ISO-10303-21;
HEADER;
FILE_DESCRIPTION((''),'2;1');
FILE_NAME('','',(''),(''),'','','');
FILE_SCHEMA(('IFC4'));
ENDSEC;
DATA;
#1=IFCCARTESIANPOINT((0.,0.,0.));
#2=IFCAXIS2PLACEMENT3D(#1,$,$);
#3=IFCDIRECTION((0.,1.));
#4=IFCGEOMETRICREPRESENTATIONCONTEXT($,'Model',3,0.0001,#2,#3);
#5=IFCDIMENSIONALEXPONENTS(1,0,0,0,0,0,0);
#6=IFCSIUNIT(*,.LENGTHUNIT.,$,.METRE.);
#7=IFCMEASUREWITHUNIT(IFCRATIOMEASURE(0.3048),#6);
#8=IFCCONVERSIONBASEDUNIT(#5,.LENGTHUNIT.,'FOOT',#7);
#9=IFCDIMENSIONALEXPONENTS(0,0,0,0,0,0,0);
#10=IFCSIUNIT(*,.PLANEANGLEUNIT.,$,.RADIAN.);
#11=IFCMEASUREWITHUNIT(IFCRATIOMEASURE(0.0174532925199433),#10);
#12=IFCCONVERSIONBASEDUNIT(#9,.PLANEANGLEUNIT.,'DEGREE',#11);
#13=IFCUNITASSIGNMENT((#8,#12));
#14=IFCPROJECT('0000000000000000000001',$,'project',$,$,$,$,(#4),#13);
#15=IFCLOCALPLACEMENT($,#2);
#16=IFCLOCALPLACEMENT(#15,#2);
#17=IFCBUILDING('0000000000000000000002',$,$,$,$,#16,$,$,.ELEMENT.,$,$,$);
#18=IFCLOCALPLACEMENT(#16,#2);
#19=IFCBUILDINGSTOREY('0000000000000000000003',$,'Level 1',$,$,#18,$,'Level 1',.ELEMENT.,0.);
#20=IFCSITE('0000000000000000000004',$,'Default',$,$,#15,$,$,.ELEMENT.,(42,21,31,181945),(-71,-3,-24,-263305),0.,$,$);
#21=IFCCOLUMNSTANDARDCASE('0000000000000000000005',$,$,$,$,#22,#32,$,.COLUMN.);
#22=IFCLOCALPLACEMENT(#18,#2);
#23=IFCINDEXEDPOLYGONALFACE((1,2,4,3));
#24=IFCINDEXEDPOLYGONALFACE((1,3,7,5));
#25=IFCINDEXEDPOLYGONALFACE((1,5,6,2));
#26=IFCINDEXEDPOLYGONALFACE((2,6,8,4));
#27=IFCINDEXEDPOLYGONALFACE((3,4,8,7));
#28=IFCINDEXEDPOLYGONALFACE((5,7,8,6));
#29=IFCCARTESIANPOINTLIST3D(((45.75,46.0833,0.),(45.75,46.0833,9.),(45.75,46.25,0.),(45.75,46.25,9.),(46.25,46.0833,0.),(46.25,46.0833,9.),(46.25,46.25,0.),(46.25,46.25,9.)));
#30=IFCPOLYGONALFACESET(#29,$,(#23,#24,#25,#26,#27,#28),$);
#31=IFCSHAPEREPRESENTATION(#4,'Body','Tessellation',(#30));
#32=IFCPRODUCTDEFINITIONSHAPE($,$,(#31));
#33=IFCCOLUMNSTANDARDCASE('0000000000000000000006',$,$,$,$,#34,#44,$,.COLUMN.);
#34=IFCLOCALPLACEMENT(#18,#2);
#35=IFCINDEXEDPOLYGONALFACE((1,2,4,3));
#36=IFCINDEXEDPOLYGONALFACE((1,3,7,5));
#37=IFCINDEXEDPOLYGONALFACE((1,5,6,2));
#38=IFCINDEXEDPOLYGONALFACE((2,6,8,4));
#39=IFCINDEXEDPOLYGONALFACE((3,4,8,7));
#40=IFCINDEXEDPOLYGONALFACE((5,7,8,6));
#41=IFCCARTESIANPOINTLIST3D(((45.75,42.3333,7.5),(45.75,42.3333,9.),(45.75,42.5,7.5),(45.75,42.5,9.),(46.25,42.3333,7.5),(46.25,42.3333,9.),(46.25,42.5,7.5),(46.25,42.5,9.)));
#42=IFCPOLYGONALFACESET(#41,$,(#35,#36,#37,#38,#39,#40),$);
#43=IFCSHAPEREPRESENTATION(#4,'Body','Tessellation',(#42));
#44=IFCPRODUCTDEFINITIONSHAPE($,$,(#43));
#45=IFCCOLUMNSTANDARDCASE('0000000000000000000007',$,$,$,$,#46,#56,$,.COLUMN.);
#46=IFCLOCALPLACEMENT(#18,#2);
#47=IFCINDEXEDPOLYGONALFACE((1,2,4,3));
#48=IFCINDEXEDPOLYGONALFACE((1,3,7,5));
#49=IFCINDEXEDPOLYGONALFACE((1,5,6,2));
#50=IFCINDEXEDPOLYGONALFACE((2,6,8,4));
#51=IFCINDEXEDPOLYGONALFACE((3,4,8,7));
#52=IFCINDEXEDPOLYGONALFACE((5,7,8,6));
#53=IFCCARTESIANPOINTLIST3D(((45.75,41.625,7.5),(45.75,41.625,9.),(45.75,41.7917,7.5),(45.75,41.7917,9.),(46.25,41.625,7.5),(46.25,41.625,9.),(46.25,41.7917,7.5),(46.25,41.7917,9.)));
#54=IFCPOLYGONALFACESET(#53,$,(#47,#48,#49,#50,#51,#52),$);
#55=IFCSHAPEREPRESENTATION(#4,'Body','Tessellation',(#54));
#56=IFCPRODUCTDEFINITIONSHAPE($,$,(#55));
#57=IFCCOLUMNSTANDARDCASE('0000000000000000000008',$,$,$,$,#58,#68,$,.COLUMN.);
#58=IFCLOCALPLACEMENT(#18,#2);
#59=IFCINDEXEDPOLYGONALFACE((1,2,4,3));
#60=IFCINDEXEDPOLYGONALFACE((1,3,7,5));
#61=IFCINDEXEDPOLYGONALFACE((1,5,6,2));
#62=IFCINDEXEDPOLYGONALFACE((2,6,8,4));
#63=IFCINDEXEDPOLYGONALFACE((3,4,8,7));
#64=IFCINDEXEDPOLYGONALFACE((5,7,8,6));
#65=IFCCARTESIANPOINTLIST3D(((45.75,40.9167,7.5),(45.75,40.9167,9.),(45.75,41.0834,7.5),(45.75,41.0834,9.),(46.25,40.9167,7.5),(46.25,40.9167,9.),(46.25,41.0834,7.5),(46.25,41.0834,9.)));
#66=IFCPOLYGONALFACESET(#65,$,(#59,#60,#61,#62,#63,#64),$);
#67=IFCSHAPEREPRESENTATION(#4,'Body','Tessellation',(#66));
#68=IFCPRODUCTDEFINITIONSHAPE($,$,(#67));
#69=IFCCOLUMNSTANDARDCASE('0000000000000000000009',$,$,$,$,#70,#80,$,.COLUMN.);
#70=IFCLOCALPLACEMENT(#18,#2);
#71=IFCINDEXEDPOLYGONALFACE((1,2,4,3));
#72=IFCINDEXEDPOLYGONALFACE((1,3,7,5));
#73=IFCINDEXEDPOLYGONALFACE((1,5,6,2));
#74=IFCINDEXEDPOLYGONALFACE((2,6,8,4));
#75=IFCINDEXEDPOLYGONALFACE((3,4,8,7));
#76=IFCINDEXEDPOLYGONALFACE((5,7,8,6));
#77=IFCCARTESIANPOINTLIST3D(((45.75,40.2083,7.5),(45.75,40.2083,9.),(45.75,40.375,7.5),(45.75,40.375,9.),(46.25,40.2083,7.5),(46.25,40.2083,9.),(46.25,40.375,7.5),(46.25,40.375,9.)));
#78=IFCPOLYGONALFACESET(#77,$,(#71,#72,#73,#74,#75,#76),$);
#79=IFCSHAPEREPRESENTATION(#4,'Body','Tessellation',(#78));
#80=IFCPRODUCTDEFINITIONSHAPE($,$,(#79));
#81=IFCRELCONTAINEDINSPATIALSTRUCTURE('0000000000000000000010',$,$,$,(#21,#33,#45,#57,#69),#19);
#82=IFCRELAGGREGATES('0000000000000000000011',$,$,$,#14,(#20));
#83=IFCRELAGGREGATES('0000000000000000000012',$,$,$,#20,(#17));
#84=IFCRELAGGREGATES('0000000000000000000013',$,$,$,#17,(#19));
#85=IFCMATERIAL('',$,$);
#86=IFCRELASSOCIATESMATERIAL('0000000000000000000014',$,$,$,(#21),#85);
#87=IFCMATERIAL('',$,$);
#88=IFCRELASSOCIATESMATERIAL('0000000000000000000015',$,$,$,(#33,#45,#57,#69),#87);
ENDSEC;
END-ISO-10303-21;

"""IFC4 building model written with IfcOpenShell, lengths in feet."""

from ifc_helpers import new_model, entity, si_unit, converted_unit, direction, frame, origin, place, context, project, spatial, rectangle, extrude, material, element, save


model = new_model("IFC4")

# Units and contexts
model_context = context("Model", 3, precision=0.0001, world=origin(), true_north=direction((0.0, 1.0)))
ifc_project = project(units=[converted_unit("LENGTHUNIT", "FOOT", entity("IfcRatioMeasure", 0.3048), si_unit("LENGTHUNIT", "METRE"), dimensions=[1, 0, 0, 0, 0, 0, 0]), converted_unit("PLANEANGLEUNIT", "DEGREE", entity("IfcRatioMeasure", 0.0174532925199433), si_unit("PLANEANGLEUNIT", "RADIAN"), dimensions=[0, 0, 0, 0, 0, 0, 0])], contexts=[model_context])

# Site, building, storey
site_placement = place(None, origin())
site = spatial("IfcSite", under=ifc_project, at=site_placement, Name="Default", CompositionType="ELEMENT", RefLatitude=(42, 21, 31, 181945), RefLongitude=(-71, -3, -24, -263305), RefElevation=0.0)
building_placement = place(site_placement, origin())
building = spatial("IfcBuilding", under=site, at=building_placement, CompositionType="ELEMENT")
storey_placement = place(building_placement, origin())
storey = spatial("IfcBuildingStorey", under=building, at=storey_placement, Name="Level 1", LongName="Level 1", CompositionType="ELEMENT", Elevation=0.0)

# Columns
ifc_material_1 = material(Name="")
wall_placement = place(storey_placement, frame((46.0, 46.25, 0.0), z_axis=(0.0, 0.0, 1.0), x_axis=(0.0, -1.0, 0.0)))
column_placement = place(wall_placement, frame((0.0833, 0.0, 0.0), z_axis=(0.0, 0.0, 1.0), x_axis=(1.0, 0.0, 0.0)))
element("IfcColumnStandardCase", 1, at=column_placement, inside=storey, material=ifc_material_1, PredefinedType="COLUMN", context=model_context, shape_type="SweptSolid", body=[
    extrude(rectangle(XDim=0.1667, YDim=0.5), origin(), (0.0, 0.0, 1.0), 9.0),
])
ifc_material_2 = material(Name="")
for number, where, z_axis, x_axis in (
    (2, (3.8334, 0.0, 7.5), (0.0, 0.0, 1.0), (1.0, 0.0, 0.0)),
    (3, (4.5417, 0.0, 7.5), (0.0, 0.0, 1.0), (1.0, 0.0, 0.0)),
    (4, (5.25, 0.0, 7.5), (0.0, 0.0, 1.0), (1.0, 0.0, 0.0)),
    (5, (5.9583, 0.0, 7.5), (0.0, 0.0, 1.0), (1.0, 0.0, 0.0)),
):
    element("IfcColumnStandardCase", number, at=place(wall_placement, frame(where, z_axis=z_axis, x_axis=x_axis)), inside=storey, material=ifc_material_2, PredefinedType="COLUMN", context=model_context, shape_type="SweptSolid", body=[
        extrude(rectangle(XDim=0.1667, YDim=0.5), origin(), (0.0, 0.0, 1.0), 1.5),
    ])

save(model, "model.ifc")
